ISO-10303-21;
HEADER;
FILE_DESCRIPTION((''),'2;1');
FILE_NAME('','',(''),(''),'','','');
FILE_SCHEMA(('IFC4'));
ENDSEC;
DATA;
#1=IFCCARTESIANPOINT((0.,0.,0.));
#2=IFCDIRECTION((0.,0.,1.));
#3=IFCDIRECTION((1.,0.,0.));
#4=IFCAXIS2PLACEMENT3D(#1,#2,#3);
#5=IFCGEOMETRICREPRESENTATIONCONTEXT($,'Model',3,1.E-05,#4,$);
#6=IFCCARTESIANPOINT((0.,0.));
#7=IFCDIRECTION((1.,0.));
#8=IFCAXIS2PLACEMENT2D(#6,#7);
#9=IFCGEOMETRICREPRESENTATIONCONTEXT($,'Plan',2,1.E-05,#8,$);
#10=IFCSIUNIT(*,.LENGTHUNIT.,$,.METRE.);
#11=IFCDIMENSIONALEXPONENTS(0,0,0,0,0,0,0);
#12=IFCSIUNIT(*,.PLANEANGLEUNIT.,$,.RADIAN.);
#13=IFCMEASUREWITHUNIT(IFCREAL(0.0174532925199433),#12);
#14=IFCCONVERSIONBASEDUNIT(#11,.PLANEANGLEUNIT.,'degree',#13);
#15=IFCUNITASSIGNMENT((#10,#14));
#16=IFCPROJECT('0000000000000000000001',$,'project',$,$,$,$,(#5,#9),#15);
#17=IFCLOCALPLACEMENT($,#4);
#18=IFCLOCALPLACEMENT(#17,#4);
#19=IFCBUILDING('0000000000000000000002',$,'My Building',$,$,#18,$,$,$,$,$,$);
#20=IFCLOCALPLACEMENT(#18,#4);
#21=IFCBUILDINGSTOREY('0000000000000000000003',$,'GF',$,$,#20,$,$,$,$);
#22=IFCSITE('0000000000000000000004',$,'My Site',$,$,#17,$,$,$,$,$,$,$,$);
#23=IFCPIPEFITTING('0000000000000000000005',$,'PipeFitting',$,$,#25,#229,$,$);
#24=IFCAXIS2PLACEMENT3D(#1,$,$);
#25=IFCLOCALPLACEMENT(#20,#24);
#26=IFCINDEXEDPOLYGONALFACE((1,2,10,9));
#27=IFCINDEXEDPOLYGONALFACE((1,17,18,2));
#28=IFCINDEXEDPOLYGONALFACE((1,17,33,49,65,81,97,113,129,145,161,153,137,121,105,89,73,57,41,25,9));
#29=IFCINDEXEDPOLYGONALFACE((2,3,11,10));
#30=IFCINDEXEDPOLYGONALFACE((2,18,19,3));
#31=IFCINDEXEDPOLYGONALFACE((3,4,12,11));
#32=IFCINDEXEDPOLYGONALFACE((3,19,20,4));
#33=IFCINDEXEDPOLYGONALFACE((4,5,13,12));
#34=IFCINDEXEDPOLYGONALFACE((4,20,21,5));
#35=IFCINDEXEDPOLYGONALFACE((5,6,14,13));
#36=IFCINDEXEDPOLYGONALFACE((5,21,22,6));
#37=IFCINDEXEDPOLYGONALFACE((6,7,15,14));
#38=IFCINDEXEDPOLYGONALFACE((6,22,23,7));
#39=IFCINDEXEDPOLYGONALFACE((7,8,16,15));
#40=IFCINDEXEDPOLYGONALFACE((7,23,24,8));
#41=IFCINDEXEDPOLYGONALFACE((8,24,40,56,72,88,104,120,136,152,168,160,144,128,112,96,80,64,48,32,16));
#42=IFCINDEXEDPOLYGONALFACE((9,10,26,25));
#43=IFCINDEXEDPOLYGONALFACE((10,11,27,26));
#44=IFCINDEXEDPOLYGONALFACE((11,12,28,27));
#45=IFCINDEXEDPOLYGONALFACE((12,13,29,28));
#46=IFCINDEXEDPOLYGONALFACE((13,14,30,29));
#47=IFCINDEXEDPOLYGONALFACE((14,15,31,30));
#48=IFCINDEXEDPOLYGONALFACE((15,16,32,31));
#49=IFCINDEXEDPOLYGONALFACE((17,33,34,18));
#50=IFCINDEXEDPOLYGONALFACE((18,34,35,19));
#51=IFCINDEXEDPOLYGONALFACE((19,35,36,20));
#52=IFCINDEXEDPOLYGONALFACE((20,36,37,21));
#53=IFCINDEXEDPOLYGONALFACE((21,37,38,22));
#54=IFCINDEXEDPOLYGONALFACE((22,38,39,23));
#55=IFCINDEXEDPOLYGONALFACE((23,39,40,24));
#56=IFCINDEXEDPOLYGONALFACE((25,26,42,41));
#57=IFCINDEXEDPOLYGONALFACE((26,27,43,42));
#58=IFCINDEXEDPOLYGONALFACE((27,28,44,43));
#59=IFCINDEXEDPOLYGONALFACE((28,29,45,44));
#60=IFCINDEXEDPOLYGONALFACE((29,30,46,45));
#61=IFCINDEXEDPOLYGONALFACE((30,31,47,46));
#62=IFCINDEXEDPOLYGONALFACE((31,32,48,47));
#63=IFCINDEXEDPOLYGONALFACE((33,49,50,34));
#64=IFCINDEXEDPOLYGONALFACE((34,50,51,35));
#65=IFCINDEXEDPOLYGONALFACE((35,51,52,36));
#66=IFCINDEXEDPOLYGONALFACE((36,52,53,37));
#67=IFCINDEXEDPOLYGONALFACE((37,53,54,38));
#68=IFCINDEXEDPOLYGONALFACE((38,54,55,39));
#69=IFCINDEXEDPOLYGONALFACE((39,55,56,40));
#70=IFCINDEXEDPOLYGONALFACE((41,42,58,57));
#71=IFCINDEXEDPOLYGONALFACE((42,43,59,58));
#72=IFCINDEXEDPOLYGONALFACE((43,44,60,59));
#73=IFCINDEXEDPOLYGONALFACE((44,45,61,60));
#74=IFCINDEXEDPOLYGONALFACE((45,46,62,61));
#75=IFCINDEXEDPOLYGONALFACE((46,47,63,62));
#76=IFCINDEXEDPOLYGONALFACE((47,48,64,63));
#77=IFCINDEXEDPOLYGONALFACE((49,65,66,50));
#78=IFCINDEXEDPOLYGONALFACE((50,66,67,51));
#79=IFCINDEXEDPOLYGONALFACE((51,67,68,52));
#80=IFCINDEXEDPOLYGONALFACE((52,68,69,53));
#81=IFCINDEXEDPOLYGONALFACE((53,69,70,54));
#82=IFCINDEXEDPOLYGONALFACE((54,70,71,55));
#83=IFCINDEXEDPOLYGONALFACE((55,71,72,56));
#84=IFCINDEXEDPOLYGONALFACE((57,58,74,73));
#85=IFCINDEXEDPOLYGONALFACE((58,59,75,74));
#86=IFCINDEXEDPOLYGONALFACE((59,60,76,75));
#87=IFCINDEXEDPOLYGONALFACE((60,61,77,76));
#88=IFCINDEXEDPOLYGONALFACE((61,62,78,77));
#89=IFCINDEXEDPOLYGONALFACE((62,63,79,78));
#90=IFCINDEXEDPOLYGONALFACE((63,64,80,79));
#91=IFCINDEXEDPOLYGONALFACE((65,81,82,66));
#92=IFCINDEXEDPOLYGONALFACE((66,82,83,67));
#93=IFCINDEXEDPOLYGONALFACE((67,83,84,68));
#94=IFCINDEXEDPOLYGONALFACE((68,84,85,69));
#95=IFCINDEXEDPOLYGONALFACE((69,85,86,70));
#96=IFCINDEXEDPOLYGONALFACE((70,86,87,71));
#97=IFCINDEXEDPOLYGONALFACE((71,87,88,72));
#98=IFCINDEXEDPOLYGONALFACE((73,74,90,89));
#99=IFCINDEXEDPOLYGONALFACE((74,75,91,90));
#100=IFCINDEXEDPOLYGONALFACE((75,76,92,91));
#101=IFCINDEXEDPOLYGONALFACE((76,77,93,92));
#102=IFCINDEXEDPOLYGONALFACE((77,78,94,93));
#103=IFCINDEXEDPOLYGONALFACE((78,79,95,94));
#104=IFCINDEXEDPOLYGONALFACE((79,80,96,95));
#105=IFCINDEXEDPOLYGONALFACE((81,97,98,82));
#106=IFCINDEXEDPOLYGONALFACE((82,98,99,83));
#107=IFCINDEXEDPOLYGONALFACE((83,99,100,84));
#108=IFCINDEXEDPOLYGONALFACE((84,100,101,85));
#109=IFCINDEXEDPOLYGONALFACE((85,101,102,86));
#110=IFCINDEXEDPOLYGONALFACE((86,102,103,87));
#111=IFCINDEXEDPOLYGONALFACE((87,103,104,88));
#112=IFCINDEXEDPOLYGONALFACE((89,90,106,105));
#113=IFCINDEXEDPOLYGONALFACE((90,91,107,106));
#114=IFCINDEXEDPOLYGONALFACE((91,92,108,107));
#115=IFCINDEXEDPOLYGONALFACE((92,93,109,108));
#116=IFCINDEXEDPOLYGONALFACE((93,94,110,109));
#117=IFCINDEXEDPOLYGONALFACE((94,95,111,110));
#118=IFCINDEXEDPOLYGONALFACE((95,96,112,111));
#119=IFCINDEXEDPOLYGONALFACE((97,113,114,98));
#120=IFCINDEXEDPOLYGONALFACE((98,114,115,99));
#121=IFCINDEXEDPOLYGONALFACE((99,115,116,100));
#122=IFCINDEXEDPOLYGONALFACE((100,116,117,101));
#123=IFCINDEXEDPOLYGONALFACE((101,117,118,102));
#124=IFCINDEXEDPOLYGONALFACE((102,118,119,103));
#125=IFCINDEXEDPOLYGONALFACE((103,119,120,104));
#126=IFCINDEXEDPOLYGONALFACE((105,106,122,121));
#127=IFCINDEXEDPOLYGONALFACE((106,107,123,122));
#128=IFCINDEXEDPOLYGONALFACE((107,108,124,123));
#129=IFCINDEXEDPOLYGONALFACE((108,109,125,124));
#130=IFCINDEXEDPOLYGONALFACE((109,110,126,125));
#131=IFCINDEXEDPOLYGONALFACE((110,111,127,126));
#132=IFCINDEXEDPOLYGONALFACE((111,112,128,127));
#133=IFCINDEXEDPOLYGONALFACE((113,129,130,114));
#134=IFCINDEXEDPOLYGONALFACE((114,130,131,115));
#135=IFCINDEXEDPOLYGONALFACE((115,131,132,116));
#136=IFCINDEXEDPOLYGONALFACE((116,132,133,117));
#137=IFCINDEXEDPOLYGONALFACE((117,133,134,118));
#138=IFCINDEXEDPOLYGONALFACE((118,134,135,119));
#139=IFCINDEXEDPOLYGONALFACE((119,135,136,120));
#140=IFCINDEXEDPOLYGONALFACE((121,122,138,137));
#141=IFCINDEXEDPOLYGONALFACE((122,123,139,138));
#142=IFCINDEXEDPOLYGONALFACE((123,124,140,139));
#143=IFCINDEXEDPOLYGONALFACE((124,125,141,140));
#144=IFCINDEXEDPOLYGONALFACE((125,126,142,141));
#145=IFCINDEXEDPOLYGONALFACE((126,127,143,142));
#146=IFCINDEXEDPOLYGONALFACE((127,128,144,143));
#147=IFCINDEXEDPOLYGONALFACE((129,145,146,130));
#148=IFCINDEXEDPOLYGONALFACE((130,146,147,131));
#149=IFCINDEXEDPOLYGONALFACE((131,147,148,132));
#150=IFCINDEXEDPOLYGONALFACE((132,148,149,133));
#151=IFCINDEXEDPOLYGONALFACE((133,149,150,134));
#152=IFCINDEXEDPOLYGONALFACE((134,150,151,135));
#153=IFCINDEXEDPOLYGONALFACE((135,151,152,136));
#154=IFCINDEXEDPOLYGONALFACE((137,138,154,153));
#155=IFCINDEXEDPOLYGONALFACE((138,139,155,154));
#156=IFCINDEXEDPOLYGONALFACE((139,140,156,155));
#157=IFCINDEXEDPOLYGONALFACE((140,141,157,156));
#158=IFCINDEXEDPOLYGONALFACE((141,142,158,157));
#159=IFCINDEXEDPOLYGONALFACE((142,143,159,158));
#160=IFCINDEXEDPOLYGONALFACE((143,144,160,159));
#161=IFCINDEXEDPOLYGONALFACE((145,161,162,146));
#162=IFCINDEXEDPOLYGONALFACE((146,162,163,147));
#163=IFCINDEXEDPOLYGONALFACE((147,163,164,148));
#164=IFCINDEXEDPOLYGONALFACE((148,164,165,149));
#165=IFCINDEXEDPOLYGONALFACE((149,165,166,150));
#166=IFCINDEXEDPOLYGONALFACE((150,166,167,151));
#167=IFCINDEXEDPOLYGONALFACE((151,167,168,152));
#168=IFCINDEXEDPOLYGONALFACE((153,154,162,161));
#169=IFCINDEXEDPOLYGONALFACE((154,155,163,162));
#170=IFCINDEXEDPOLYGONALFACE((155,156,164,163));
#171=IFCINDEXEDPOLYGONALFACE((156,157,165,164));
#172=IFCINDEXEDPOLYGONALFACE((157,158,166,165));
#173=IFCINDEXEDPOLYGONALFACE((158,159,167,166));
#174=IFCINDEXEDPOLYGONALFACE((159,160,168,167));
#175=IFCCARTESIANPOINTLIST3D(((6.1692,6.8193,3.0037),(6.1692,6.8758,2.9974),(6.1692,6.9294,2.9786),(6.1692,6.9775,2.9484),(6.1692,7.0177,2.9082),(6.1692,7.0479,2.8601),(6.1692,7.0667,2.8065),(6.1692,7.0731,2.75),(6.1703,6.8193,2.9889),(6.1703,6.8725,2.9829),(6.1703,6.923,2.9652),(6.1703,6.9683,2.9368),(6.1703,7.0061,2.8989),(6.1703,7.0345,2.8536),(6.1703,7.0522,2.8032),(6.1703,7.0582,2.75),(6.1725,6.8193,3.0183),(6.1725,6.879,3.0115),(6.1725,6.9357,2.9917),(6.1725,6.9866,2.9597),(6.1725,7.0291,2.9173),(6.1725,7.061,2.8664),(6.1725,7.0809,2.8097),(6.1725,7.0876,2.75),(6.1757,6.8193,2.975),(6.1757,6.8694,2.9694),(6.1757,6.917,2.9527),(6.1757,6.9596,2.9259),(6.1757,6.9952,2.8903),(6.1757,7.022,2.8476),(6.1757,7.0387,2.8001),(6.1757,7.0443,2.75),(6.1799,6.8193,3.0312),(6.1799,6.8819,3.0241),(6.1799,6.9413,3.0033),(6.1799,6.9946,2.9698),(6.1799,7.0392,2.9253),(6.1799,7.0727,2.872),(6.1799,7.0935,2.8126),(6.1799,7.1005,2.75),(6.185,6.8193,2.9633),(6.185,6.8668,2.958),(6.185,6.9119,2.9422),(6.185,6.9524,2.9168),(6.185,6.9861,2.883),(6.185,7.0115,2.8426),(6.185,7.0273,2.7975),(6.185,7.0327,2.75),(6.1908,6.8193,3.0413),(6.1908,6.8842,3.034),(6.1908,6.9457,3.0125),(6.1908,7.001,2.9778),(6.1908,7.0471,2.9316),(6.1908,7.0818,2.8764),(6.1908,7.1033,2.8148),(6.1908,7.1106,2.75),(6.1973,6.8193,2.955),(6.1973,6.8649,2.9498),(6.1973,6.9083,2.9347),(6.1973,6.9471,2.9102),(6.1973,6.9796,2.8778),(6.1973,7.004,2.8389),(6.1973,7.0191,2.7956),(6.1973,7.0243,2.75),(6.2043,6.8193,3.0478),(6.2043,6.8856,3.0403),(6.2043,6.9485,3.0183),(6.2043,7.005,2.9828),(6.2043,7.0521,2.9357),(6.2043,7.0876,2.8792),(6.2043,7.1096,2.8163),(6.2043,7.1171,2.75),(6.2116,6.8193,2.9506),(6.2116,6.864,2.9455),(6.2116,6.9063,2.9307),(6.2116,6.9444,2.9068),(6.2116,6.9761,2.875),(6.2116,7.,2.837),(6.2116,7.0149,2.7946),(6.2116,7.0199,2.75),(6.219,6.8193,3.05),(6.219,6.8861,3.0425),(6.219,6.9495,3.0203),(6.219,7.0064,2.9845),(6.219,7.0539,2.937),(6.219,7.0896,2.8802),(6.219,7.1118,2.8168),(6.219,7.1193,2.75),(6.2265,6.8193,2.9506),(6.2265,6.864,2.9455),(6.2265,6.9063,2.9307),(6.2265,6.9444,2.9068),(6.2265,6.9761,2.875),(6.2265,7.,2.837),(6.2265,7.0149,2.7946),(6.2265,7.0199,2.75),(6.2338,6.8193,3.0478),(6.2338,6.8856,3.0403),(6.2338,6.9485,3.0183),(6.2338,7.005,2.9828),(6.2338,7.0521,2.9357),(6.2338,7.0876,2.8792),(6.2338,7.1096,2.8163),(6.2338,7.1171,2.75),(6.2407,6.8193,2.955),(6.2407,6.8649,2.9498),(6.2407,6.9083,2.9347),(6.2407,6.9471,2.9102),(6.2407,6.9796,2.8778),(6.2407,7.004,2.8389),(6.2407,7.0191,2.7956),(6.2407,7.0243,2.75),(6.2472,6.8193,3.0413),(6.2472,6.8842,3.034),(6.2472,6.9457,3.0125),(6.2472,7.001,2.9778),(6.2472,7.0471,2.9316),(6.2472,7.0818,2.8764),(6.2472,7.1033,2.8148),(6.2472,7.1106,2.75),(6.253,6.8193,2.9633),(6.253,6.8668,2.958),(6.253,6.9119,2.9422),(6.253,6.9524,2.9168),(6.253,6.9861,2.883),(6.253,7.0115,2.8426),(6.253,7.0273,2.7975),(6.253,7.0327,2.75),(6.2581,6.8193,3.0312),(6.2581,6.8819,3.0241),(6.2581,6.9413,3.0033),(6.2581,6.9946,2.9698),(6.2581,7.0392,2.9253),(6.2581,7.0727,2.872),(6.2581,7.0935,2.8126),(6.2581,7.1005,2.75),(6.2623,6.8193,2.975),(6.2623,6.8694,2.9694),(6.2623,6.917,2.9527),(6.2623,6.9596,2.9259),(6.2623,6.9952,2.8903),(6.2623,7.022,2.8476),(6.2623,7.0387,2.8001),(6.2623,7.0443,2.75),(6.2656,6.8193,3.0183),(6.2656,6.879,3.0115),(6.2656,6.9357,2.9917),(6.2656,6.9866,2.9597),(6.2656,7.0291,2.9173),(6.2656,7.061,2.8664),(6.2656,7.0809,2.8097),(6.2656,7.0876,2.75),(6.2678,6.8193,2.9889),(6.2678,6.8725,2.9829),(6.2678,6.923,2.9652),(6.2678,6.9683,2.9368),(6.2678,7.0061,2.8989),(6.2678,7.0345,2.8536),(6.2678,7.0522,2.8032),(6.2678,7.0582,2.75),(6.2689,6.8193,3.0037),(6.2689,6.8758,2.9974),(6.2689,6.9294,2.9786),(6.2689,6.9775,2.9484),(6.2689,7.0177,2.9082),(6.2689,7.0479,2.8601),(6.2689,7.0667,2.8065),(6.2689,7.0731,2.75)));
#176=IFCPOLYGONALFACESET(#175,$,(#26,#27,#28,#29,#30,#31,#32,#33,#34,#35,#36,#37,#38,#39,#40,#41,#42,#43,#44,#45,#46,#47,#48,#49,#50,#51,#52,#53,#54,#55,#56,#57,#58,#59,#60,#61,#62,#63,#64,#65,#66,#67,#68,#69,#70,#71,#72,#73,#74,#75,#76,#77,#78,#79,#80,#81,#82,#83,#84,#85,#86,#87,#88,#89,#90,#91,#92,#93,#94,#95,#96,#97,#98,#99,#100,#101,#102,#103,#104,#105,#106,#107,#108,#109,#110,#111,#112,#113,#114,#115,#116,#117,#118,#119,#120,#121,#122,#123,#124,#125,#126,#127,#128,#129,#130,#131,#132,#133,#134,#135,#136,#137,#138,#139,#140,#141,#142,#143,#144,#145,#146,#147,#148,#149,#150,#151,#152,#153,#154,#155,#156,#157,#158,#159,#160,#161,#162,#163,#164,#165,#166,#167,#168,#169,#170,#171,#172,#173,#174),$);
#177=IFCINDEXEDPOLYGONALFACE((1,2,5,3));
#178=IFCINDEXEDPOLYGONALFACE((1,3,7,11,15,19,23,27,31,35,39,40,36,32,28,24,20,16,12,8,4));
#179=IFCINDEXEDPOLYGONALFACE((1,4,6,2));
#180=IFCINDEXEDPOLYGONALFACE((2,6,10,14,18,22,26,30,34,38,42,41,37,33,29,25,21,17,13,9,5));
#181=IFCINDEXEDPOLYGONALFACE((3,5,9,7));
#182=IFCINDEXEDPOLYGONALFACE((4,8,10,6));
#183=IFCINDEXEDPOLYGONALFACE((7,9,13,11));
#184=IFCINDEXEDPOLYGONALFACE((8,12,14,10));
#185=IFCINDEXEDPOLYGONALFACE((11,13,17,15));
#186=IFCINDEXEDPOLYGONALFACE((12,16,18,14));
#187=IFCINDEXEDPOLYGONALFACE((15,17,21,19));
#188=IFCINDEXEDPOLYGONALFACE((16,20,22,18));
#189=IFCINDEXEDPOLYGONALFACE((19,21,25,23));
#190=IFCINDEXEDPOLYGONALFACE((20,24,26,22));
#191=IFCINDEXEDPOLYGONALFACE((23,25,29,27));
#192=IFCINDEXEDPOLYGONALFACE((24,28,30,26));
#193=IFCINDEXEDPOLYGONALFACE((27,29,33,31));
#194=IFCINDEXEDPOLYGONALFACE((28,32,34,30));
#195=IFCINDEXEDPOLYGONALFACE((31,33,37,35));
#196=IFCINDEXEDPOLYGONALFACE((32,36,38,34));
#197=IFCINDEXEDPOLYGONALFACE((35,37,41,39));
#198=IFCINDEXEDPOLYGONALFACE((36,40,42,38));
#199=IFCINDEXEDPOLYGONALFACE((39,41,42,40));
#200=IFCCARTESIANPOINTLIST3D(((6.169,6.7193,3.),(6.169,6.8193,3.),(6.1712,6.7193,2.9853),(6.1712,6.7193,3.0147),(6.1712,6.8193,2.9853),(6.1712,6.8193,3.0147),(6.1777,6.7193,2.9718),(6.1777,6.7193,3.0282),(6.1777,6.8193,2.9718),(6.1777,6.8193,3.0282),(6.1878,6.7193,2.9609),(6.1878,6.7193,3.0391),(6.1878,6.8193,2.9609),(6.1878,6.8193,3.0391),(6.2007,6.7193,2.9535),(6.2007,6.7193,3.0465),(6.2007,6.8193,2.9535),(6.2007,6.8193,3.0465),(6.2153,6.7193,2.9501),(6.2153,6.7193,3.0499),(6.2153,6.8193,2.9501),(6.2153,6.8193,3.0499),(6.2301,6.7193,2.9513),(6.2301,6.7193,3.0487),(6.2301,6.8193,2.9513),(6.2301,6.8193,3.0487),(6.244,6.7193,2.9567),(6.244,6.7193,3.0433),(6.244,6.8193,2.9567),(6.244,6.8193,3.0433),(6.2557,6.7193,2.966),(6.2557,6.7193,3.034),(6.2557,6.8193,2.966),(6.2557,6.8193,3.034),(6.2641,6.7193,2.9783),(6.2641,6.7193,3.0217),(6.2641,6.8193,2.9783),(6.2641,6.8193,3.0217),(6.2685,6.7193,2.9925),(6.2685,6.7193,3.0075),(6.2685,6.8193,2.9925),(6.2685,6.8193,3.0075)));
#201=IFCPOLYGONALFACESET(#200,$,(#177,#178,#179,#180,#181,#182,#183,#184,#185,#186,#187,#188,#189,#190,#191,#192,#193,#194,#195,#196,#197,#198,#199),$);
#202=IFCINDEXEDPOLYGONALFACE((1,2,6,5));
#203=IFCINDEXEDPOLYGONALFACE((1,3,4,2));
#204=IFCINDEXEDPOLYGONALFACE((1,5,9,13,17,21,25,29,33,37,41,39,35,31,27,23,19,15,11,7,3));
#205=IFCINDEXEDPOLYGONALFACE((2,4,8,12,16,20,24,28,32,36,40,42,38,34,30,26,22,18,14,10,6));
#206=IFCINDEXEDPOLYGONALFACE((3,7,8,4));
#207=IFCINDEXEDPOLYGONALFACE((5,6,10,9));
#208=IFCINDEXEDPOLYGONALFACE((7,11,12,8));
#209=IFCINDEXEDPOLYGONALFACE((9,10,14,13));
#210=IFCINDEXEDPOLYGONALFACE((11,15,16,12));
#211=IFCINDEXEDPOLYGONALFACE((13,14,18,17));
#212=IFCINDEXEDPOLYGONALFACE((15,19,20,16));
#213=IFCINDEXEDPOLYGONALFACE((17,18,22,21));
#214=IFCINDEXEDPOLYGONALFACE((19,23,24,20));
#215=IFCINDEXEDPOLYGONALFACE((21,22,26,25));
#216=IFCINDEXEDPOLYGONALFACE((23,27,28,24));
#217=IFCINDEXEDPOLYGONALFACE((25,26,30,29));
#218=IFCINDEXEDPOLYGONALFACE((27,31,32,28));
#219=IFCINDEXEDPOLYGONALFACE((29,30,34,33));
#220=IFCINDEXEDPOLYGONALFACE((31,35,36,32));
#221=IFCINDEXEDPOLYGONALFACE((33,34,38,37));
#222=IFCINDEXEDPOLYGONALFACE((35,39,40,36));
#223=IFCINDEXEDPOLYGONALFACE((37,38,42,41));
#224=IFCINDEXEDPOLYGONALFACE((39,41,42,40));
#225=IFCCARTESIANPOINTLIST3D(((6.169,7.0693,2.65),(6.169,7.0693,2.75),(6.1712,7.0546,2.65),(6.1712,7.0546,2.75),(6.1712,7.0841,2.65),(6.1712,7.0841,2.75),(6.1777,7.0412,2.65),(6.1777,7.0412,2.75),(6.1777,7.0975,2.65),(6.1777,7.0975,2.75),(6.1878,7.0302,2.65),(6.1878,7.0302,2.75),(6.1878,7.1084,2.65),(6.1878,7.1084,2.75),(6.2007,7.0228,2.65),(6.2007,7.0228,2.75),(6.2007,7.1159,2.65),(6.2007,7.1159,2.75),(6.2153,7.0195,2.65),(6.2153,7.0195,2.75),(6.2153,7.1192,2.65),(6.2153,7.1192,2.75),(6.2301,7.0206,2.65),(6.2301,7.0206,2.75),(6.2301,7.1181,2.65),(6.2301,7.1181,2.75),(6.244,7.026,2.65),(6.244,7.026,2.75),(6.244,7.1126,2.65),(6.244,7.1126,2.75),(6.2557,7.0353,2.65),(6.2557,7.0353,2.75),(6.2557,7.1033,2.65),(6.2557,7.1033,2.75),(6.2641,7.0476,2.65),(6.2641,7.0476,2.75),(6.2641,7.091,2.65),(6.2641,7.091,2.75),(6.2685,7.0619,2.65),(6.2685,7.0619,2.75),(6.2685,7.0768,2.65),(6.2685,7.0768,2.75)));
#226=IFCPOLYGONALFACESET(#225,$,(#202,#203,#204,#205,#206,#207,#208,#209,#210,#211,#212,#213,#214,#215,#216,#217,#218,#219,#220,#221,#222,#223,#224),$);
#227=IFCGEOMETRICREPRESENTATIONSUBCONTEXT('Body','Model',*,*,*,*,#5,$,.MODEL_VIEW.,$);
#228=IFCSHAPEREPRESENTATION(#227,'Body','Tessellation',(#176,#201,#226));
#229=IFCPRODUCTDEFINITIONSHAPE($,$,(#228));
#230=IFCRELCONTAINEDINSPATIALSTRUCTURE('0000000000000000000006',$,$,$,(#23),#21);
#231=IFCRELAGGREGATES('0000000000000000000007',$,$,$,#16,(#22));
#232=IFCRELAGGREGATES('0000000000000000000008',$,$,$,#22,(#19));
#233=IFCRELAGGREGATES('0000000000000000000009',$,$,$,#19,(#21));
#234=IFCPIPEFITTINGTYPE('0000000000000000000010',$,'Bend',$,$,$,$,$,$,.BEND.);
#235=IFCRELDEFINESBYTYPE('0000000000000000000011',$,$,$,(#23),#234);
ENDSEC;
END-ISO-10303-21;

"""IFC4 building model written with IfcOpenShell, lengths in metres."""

from ifc_helpers import new_model, entity, si_unit, converted_unit, frame, origin_with_axes, origin_2d_with_axis, place, context, subcontext, project, spatial, circle, extrude, source, transform, mapped, type_object, type_shapes, element, save


model = new_model("IFC4")

# Units and contexts
model_context = context("Model", 3, precision=1e-05, world=origin_with_axes())
plan_context = context("Plan", 2, precision=1e-05, world=origin_2d_with_axis())
body_context = subcontext(model_context, "Body", "Model", "MODEL_VIEW")
ifc_project = project(units=[si_unit("LENGTHUNIT", "METRE"), converted_unit("PLANEANGLEUNIT", "degree", entity("IfcReal", 0.0174532925199433), si_unit("PLANEANGLEUNIT", "RADIAN"), dimensions=[0, 0, 0, 0, 0, 0, 0])], contexts=[model_context, plan_context])

# Site, building, storey
site_placement = place(None, origin_with_axes())
site = spatial("IfcSite", under=ifc_project, at=site_placement, Name="My Site")
building_placement = place(site_placement, origin_with_axes())
building = spatial("IfcBuilding", under=site, at=building_placement, Name="My Building")
storey_placement = place(building_placement, origin_with_axes())
storey = spatial("IfcBuildingStorey", under=building, at=storey_placement, Name="GF")

# Pipe fitting
pipe_fitting_type = type_object("IfcPipeFittingType", Name="Bend", PredefinedType="BEND")
shared_shape = source(origin_with_axes(), body_context, "Body", "SolidModel", [
    entity("IfcSweptDiskSolid", entity("IfcIndexedPolyCurve", entity("IfcCartesianPointList3D", [[0.0, 0.0, 0.1], [0.0, -0.0732, 0.2768], [0.0, -0.25, 0.35]]), [entity("IfcArcIndex", [1, 2, 3])]), 0.05),
    extrude(circle(Radius=0.05), origin_with_axes(), (0.0, 0.0, 1.0), 0.1),
    extrude(circle(Radius=0.05), frame((0.0, -0.25, 0.35), z_axis=(0.0, -1.0, 0.0), x_axis=(1.0, 0.0, 0.0)), (0.0, 0.0, 1.0), 0.1),
])
type_shapes(pipe_fitting_type, [shared_shape])
for number, where, z_axis, x_axis, name in (
    (1, (6.219, 6.7193, 3.0), (0.0, 1.0, 0.0), (-1.0, 0.0, 0.0), "PipeFitting"),
):
    element("IfcPipeFitting", number, at=place(storey_placement, frame(where, z_axis=z_axis, x_axis=x_axis)), inside=storey, type_object=pipe_fitting_type, Name=name, context=body_context, shape_type="MappedRepresentation", body=[
        mapped(shared_shape, transform((0.0, 0.0, 0.0), x_axis=(1.0, 0.0, 0.0), y_axis=(0.0, 1.0, 0.0), z_axis=(0.0, 0.0, 1.0), scale=1.0)),
    ])

save(model, "model.ifc")
